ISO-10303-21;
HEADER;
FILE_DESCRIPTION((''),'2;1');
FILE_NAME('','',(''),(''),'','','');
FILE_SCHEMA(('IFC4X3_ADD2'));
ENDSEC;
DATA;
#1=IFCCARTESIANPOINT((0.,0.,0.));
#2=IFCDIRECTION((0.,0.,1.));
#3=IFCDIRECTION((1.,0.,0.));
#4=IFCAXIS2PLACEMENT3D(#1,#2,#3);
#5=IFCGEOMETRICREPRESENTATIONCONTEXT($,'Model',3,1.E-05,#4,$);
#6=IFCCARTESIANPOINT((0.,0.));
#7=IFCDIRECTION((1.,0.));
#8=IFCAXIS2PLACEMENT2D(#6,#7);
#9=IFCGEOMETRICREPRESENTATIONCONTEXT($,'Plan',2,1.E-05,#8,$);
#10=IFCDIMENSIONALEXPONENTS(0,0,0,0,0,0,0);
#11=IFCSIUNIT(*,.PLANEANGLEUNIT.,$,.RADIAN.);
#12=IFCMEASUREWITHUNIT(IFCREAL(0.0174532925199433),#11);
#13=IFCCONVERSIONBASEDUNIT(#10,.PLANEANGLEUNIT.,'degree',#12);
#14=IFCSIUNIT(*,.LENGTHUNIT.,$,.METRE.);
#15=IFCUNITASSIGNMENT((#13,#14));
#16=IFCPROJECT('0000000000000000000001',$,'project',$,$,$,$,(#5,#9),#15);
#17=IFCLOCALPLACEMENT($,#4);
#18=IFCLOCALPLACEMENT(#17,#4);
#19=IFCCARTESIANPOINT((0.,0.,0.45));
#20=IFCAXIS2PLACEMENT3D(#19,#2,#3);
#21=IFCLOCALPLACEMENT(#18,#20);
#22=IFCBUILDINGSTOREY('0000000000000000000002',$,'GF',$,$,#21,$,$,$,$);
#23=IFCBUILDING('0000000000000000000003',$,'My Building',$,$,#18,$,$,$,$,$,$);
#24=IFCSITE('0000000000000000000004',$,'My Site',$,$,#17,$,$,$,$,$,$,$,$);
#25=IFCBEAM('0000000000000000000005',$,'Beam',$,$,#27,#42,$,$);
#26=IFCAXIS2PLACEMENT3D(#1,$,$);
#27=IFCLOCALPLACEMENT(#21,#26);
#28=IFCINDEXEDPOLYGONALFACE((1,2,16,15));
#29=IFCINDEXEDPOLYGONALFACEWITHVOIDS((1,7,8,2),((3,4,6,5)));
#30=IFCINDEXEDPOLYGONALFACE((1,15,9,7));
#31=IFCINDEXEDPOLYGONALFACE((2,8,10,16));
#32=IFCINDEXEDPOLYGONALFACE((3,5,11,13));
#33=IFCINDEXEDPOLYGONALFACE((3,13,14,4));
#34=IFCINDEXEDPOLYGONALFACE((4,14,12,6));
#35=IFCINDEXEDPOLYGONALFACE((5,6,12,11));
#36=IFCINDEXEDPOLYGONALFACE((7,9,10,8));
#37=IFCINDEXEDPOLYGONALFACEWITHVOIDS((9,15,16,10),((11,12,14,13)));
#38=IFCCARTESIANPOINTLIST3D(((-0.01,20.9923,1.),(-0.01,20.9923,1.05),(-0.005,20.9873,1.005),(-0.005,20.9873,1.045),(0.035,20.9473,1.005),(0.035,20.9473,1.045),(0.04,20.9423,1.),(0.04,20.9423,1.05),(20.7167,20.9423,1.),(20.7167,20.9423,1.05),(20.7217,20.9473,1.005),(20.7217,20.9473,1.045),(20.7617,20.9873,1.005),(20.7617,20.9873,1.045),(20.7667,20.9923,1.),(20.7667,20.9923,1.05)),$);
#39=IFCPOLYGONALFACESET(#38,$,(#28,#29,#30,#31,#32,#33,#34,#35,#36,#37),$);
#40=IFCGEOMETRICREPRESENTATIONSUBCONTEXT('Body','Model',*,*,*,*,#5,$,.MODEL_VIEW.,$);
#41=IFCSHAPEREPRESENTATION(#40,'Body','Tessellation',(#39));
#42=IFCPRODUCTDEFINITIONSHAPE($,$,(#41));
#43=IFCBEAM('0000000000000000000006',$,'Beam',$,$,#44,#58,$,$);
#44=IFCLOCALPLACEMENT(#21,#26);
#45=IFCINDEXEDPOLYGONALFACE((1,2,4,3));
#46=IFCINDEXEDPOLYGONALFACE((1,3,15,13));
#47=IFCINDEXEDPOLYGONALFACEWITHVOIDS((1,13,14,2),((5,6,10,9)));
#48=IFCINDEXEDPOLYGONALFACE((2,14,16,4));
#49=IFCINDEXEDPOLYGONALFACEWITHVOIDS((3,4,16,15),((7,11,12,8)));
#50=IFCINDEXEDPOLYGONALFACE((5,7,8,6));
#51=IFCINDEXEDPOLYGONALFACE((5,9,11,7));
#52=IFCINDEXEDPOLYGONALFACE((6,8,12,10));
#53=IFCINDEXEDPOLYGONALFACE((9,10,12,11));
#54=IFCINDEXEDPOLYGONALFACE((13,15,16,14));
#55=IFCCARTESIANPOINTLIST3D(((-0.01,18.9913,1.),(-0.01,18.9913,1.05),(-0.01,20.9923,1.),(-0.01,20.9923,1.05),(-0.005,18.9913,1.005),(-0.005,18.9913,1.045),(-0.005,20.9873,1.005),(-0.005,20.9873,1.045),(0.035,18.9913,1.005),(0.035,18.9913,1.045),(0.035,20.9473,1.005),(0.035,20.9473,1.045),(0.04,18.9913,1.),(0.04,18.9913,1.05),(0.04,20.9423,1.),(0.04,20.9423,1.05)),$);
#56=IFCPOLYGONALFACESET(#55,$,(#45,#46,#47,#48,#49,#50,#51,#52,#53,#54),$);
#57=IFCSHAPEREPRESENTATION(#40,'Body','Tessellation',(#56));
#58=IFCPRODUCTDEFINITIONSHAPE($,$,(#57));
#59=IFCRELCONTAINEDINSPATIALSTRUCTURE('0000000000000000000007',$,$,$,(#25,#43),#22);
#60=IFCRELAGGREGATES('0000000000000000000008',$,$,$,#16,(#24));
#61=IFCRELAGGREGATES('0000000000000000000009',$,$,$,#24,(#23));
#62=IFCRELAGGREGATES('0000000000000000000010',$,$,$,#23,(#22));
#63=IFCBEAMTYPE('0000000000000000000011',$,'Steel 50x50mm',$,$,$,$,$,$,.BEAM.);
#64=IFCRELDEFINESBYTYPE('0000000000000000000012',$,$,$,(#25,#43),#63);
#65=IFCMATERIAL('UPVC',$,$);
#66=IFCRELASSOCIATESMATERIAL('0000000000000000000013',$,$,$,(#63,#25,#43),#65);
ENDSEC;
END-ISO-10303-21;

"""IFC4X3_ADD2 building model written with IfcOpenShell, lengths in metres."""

from ifc_helpers import new_model, entity, si_unit, converted_unit, frame, origin_with_axes, origin_2d_with_axis, place, context, subcontext, project, spatial, hollow_rectangle, extrude, clip, halfspace, material, material_profile, profile_set, profile_usage, type_object, element, save


model = new_model("IFC4X3_ADD2")

# Units and contexts
model_context = context("Model", 3, precision=1e-05, world=origin_with_axes())
plan_context = context("Plan", 2, precision=1e-05, world=origin_2d_with_axis())
body_context_1 = subcontext(model_context, "Body", "Model", "MODEL_VIEW")
ifc_project = project(units=[converted_unit("PLANEANGLEUNIT", "degree", entity("IfcReal", 0.0174532925199433), si_unit("PLANEANGLEUNIT", "RADIAN"), dimensions=[0, 0, 0, 0, 0, 0, 0]), si_unit("LENGTHUNIT", "METRE")], contexts=[model_context, plan_context])

# Site, building, storey
site_placement = place(None, origin_with_axes())
site = spatial("IfcSite", under=ifc_project, at=site_placement, Name="My Site")
building_placement = place(site_placement, origin_with_axes())
building = spatial("IfcBuilding", under=site, at=building_placement, Name="My Building")
storey_placement = place(building_placement, frame((0.0, 0.0, 0.45), z_axis=(0.0, 0.0, 1.0), x_axis=(1.0, 0.0, 0.0)))
storey = spatial("IfcBuildingStorey", under=building, at=storey_placement, Name="GF")

# Beams
ifc_material_1 = material(Name="UPVC")
ifc_material_profile_1 = material_profile(ifc_material_1, hollow_rectangle(XDim=0.05, YDim=0.05, WallThickness=0.005))
ifc_material_profile_2 = material_profile(ifc_material_1, hollow_rectangle(XDim=0.05, YDim=0.05, WallThickness=0.005))
ifc_profile_set = profile_set([ifc_material_profile_1, ifc_material_profile_2])
ifc_profile_usage_1 = profile_usage(ifc_profile_set, cardinal=5)
beam_type = type_object("IfcBeamType", Name="Steel 50x50mm", PredefinedType="BEAM", material=ifc_profile_set)
beam_1_placement = place(storey_placement, frame((-0.01, 20.9673, 1.025), z_axis=(1.0, 0.0, 0.0), x_axis=(0.0, 1.0, 0.0)))
element("IfcBeam", 1, at=beam_1_placement, inside=storey, type_object=beam_type, material=ifc_profile_usage_1, Name="Beam", context=body_context_1, shape_type="Clipping", body=[
    clip(clip(extrude(hollow_rectangle(XDim=0.05, YDim=0.05, WallThickness=0.005), origin_with_axes(), (0.0, 0.0, 1.0), 20.7767), halfspace(frame((0.025, -1.475, 20.7767), z_axis=(-0.707107, 0.0, 0.707107), x_axis=(0.0, 1.0, 0.0)), False)), halfspace(frame((0.025, -1.475, 0.0), z_axis=(-0.707112, 0.0, -0.707101), x_axis=(0.0, 1.0, 0.0)), False)),
])
ifc_profile_usage_2 = profile_usage(ifc_profile_set, cardinal=5)
beam_2_placement = place(storey_placement, frame((0.015, 18.9913, 1.025), z_axis=(0.0, 1.0, 0.0), x_axis=(-1.0, 0.0, 0.0)))
element("IfcBeam", 2, at=beam_2_placement, inside=storey, type_object=beam_type, material=ifc_profile_usage_2, Name="Beam", context=body_context_1, shape_type="Clipping", body=[
    clip(extrude(hollow_rectangle(XDim=0.05, YDim=0.05, WallThickness=0.005), origin_with_axes(), (0.0, 0.0, 1.0), 2.0009), halfspace(frame((0.025, -1.475, 2.0009), z_axis=(-0.707101, 0.0, 0.707112), x_axis=(0.0, 1.0, 0.0)), False)),
])

save(model, "model.ifc")
